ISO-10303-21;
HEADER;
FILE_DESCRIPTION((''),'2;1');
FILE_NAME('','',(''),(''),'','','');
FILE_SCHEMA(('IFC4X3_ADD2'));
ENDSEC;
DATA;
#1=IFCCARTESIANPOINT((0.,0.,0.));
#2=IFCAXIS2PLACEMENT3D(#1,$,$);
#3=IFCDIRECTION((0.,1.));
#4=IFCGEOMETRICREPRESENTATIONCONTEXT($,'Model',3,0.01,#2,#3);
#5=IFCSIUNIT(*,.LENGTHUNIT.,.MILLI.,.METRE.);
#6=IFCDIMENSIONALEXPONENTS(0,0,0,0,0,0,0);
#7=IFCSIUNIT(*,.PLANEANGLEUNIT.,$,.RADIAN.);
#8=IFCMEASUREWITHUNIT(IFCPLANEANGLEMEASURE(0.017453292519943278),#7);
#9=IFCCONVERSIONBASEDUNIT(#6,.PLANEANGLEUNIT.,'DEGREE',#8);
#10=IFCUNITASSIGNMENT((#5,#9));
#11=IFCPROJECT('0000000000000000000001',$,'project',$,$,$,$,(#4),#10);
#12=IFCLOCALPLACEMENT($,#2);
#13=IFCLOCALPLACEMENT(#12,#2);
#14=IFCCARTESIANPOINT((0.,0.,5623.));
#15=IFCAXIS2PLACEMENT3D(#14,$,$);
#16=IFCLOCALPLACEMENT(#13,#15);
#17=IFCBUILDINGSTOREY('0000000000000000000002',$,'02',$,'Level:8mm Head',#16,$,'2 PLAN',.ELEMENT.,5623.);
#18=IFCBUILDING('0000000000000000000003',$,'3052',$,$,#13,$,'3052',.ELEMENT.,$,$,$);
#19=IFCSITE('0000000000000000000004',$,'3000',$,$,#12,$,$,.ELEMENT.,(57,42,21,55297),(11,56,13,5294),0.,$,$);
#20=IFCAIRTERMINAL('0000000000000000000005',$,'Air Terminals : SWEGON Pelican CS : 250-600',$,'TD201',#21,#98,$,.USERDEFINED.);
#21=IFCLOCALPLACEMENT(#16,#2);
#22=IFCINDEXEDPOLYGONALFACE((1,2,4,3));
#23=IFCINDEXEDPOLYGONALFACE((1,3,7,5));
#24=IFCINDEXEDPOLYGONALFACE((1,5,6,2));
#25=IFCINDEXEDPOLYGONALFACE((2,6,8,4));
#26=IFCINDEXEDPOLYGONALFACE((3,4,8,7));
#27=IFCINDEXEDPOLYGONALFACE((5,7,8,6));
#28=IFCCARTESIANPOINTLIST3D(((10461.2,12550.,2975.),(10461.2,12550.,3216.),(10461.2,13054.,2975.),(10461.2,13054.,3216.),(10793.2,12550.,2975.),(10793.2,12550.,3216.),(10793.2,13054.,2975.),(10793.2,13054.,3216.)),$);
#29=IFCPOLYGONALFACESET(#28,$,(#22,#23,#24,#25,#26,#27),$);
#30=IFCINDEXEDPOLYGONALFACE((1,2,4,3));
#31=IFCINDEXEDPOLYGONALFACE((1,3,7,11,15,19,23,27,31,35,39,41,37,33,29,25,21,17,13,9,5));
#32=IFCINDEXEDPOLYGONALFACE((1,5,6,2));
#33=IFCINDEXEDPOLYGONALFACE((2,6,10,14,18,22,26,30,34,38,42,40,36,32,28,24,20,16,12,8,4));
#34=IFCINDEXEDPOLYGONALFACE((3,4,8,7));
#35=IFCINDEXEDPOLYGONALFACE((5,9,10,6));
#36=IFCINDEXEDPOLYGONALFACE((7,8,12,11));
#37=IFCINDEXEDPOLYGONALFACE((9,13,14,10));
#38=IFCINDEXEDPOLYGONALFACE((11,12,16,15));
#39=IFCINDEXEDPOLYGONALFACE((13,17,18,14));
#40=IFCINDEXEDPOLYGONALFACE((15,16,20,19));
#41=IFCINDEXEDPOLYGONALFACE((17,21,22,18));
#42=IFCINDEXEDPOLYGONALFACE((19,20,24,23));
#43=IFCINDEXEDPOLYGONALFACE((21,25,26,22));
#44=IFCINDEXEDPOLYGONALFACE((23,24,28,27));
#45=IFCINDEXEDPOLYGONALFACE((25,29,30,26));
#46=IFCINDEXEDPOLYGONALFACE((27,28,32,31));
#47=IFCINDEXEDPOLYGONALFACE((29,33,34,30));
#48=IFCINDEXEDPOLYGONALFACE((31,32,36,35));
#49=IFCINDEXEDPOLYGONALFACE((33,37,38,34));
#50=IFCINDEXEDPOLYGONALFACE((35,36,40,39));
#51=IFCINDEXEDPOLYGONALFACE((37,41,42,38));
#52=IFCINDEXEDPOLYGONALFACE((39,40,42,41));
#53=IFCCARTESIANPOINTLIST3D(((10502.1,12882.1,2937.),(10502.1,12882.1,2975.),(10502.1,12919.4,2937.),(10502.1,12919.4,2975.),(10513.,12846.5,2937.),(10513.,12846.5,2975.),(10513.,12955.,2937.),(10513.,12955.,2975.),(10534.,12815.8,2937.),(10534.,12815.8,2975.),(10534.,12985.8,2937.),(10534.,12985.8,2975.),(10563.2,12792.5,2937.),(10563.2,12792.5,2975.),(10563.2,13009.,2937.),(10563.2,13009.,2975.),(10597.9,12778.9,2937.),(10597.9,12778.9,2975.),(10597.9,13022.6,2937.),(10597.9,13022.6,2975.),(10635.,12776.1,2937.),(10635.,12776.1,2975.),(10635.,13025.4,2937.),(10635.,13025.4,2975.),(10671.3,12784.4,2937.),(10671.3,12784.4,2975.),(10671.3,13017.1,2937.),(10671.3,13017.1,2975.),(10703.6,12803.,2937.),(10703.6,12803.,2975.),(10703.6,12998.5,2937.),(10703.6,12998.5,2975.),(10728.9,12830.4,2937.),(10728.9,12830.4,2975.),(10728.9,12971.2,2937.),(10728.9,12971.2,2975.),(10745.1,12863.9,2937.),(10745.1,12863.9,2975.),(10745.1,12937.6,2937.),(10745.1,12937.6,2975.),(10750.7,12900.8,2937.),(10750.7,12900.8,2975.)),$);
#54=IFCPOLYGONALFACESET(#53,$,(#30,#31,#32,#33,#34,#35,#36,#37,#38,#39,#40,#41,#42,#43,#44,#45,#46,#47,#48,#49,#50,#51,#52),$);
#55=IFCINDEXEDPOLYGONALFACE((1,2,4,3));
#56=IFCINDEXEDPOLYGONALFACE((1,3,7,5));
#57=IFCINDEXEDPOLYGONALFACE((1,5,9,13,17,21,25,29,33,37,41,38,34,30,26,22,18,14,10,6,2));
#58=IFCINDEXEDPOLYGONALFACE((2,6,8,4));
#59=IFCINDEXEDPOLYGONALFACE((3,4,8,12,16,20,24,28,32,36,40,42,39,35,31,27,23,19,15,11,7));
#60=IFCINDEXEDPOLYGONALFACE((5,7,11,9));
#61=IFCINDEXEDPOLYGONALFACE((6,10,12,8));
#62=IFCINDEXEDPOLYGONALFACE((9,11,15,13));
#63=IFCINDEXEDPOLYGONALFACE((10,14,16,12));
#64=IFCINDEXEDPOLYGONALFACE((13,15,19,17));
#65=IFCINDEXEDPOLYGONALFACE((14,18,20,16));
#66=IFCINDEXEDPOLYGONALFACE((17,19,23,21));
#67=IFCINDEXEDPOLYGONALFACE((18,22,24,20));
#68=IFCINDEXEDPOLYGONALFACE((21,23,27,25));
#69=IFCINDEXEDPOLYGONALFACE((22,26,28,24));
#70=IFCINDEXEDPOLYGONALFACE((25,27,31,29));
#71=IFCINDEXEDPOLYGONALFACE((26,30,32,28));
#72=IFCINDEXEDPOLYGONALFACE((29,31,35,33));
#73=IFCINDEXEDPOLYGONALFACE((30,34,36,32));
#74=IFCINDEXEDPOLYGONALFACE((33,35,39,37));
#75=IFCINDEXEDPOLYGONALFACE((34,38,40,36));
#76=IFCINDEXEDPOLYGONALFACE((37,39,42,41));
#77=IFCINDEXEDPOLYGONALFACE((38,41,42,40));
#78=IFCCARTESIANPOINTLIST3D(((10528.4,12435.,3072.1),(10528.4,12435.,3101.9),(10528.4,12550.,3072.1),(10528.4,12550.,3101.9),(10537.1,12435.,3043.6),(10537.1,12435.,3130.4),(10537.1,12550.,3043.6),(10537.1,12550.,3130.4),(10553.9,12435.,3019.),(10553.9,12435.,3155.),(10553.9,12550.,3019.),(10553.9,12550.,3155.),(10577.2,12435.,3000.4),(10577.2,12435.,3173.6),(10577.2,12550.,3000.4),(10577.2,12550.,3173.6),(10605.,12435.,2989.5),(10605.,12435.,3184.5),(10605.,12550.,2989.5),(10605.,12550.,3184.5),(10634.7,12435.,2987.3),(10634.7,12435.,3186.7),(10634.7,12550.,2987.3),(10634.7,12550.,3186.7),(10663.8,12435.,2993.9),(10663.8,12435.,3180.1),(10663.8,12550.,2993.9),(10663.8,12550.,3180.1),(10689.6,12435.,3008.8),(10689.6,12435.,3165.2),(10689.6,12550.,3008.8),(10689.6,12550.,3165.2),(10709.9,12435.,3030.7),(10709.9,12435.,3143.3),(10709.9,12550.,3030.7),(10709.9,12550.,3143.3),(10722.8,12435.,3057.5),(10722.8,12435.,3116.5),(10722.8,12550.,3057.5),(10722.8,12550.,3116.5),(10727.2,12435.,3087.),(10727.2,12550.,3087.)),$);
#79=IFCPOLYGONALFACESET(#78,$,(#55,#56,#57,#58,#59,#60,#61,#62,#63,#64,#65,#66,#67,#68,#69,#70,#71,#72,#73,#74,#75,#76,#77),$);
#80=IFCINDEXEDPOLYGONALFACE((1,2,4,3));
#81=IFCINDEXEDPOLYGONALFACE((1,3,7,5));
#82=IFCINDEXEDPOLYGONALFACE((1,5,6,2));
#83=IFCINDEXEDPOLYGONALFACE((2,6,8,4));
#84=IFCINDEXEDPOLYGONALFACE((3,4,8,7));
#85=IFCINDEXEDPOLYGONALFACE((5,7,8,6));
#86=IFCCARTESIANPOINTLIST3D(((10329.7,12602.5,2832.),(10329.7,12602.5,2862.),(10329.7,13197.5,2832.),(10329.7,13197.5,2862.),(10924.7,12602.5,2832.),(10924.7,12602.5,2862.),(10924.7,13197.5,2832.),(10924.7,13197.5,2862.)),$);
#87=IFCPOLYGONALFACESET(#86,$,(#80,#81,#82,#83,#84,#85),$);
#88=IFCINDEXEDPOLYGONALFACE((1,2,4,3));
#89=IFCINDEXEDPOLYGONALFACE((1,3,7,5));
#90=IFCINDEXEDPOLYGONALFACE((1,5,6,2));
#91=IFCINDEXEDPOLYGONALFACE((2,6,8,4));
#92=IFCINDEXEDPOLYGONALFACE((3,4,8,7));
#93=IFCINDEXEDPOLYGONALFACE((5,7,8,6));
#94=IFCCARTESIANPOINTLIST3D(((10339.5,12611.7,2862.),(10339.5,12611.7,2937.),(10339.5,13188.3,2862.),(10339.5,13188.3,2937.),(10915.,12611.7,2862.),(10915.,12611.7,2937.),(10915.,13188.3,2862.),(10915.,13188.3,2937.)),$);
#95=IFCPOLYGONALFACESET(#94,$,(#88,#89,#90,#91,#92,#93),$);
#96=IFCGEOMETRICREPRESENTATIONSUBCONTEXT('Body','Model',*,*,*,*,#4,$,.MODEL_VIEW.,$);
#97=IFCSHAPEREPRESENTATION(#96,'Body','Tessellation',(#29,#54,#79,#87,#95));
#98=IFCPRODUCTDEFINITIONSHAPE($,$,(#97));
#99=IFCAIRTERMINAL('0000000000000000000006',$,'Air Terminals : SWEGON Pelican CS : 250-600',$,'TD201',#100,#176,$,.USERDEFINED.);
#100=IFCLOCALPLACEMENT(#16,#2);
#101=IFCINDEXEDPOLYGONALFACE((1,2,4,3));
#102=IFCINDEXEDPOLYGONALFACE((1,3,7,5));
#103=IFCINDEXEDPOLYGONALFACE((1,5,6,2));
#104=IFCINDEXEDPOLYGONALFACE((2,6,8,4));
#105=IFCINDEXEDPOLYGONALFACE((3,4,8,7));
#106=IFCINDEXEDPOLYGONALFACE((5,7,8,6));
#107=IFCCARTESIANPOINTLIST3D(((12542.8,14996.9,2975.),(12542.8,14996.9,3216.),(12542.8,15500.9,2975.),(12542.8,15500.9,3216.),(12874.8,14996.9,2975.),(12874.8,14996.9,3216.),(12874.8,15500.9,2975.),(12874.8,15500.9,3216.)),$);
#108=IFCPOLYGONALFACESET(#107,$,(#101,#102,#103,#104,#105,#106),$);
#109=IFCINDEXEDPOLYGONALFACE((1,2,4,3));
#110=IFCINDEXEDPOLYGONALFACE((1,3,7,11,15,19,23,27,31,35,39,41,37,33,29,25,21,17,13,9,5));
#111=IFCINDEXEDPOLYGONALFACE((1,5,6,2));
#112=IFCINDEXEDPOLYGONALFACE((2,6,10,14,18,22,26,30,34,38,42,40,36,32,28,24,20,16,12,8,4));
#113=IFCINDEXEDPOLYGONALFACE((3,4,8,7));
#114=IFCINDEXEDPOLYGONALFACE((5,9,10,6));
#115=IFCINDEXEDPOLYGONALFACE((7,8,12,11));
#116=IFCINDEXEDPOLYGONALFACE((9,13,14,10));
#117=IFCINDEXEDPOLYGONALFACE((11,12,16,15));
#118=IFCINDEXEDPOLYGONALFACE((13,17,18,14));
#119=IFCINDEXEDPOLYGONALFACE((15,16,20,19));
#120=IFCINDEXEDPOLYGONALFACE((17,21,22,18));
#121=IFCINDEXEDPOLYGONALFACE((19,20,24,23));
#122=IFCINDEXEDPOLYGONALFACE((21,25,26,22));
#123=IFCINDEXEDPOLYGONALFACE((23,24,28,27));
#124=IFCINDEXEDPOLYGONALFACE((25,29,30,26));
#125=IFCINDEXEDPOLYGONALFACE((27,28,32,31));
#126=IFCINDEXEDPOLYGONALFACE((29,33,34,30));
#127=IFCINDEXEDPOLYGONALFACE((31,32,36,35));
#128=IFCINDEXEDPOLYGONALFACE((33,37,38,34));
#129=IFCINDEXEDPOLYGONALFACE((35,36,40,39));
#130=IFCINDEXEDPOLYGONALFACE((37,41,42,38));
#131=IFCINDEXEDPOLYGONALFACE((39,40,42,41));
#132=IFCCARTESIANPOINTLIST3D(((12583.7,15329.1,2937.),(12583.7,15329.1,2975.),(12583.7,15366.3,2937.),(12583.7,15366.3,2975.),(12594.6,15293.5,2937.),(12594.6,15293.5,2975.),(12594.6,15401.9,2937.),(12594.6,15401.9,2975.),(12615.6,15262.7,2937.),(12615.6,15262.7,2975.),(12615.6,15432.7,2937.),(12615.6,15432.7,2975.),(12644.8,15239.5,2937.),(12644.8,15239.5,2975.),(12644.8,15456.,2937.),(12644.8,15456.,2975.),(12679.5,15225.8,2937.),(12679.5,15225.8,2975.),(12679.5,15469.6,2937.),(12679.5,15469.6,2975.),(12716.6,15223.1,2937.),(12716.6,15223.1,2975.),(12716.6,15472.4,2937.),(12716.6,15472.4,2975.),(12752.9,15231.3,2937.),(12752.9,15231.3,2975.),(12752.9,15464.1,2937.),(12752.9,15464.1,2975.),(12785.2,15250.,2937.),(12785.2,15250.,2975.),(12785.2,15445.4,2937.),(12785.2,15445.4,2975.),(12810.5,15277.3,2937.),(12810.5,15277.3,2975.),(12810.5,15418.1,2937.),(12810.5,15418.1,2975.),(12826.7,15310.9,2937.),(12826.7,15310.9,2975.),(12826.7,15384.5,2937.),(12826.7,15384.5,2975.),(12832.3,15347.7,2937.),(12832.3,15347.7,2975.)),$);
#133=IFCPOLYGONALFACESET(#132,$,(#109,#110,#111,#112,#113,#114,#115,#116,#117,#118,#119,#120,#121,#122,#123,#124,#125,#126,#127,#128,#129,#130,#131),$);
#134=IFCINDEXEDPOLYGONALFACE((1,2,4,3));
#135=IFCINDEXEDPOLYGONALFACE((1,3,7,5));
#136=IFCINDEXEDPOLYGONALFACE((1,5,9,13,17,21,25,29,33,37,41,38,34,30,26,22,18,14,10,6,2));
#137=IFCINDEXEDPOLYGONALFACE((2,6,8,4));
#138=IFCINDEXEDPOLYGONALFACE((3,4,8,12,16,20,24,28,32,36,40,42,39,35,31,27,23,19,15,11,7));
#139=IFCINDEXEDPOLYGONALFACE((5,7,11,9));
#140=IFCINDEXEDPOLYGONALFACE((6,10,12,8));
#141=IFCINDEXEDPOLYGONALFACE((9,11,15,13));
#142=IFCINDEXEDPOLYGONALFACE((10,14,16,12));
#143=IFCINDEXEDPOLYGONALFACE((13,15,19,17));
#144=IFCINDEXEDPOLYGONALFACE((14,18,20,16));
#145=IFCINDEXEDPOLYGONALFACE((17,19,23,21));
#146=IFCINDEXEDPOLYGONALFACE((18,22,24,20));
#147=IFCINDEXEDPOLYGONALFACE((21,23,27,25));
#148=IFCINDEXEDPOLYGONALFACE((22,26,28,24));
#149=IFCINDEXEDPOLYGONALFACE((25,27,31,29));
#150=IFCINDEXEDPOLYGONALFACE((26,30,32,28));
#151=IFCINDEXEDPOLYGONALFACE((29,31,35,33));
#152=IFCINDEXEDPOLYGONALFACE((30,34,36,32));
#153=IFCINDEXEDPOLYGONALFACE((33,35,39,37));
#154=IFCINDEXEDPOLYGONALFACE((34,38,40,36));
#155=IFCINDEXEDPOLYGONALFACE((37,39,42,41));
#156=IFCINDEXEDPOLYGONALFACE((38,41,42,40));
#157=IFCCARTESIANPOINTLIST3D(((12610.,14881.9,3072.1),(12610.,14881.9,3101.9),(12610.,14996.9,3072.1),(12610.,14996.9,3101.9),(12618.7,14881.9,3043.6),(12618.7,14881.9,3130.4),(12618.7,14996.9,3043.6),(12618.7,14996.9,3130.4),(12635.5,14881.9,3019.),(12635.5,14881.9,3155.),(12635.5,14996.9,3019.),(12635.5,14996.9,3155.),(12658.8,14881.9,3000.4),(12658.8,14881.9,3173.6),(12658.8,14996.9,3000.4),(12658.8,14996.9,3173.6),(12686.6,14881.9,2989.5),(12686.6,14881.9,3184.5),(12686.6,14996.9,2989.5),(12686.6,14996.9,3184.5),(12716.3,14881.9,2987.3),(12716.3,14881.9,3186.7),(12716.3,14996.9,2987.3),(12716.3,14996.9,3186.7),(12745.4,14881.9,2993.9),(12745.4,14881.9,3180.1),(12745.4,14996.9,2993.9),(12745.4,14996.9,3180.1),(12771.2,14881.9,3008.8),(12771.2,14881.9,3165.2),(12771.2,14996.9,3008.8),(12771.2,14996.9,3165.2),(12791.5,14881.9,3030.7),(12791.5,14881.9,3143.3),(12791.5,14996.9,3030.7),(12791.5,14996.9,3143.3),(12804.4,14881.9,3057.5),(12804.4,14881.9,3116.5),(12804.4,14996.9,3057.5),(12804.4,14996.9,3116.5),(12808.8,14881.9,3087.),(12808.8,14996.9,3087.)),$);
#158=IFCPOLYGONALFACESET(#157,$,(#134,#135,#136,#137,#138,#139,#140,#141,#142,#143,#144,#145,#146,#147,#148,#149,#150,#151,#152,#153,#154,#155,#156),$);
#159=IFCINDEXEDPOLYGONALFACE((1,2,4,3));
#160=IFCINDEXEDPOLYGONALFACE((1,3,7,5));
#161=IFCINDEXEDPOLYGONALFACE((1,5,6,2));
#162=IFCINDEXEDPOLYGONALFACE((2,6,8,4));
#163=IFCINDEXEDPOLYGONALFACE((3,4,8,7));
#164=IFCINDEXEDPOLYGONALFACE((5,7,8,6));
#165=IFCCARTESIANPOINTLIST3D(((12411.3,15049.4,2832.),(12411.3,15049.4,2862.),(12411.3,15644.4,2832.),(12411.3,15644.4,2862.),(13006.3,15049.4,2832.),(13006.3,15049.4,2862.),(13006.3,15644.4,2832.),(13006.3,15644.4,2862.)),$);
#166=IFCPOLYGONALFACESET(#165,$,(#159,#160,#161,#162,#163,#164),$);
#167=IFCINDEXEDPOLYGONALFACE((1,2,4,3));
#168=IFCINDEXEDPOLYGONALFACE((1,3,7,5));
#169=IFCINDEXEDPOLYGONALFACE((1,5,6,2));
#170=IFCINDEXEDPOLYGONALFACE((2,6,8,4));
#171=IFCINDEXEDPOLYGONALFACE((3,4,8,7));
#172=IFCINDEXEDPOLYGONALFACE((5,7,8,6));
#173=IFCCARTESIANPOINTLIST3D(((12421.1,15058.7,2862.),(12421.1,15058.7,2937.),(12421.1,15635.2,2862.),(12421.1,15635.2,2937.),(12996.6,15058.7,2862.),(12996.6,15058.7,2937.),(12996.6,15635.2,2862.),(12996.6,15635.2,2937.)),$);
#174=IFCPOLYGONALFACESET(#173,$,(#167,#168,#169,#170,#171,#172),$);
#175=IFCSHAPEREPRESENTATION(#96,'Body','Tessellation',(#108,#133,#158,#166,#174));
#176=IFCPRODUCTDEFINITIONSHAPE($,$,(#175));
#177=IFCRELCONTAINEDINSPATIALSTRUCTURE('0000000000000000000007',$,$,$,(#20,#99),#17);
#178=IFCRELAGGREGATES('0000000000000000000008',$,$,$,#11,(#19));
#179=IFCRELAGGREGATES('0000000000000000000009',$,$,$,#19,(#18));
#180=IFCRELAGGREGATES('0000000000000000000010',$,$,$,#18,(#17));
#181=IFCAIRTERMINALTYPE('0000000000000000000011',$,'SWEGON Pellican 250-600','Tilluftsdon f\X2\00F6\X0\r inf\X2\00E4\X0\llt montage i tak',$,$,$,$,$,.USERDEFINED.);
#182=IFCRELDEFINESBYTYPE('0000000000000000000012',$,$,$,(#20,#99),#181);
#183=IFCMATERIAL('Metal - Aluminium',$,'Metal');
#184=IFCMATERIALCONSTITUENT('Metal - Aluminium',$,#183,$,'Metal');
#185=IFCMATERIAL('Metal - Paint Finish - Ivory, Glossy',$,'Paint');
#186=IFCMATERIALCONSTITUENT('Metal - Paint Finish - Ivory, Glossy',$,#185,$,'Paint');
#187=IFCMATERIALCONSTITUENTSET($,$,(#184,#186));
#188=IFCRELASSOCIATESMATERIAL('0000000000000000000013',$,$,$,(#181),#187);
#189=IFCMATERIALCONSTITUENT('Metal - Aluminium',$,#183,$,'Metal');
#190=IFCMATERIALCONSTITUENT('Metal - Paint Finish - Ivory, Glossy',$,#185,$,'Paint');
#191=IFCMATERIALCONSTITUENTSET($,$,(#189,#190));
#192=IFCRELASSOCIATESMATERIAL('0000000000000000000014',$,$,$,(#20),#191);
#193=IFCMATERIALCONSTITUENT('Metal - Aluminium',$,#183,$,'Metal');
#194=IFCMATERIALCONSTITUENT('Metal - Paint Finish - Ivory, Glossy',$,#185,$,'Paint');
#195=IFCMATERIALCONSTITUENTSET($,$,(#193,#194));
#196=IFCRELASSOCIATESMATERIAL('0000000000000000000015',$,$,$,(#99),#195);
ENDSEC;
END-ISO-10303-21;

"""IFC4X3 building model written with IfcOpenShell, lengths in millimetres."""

from ifc_helpers import new_model, entity, si_unit, converted_unit, direction, frame, frame_2d, origin, origin_2d_with_axis, place, context, subcontext, project, spatial, rectangle, circle, extrude, source, transform, mapped, material, constituent, constituent_set, type_object, type_shapes, element, save


model = new_model("IFC4X3")

# Units and contexts
model_context = context("Model", 3, precision=0.01, world=origin(), true_north=direction((0.0, 1.0)))
body_context = subcontext(model_context, "Body", "Model", "MODEL_VIEW")
ifc_project = project(units=[si_unit("LENGTHUNIT", "METRE", prefix="MILLI"), converted_unit("PLANEANGLEUNIT", "DEGREE", entity("IfcPlaneAngleMeasure", 0.017453292519943278), si_unit("PLANEANGLEUNIT", "RADIAN"), dimensions=[0, 0, 0, 0, 0, 0, 0])], contexts=[model_context])

# Site, building, storey
site_placement = place(None, origin())
site = spatial("IfcSite", under=ifc_project, at=site_placement, Name="3000", CompositionType="ELEMENT", RefLatitude=(57, 42, 21, 55297), RefLongitude=(11, 56, 13, 5294), RefElevation=0.0)
building_placement = place(site_placement, origin())
building = spatial("IfcBuilding", under=site, at=building_placement, Name="3052", LongName="3052", CompositionType="ELEMENT")
storey_placement = place(building_placement, frame((0.0, 0.0, 5623.0)))
storey = spatial("IfcBuildingStorey", under=building, at=storey_placement, Name="02", ObjectType="Level:8mm Head", LongName="2 PLAN", CompositionType="ELEMENT", Elevation=5623.0)

# Air terminals
ifc_material_1 = material(Name="Metal - Aluminium", Category="Metal")
ifc_constituent_1 = constituent(ifc_material_1, Name="Metal - Aluminium", Category="Metal")
ifc_material_2 = material(Name="Metal - Paint Finish - Ivory, Glossy", Category="Paint")
ifc_constituent_2 = constituent(ifc_material_2, Name="Metal - Paint Finish - Ivory, Glossy", Category="Paint")
ifc_constituent_set_1 = constituent_set(constituents=[ifc_constituent_1, ifc_constituent_2])
ifc_constituent_3 = constituent(ifc_material_1, Name="Metal - Aluminium", Category="Metal")
ifc_constituent_4 = constituent(ifc_material_2, Name="Metal - Paint Finish - Ivory, Glossy", Category="Paint")
ifc_constituent_set_2 = constituent_set(constituents=[ifc_constituent_3, ifc_constituent_4])
air_terminal_type_1 = type_object("IfcAirTerminalType", Name="SWEGON Pellican 250-600", Description="Tilluftsdon för infällt montage i tak", PredefinedType="USERDEFINED", material=ifc_constituent_set_2)
shared_shape_1 = source(origin(), body_context, "Body", "SweptSolid", [
    extrude(rectangle(XDim=332.0, YDim=504.0, at=origin_2d_with_axis()), frame((0.0, 98.0, -354.0), z_axis=(0.0, 0.0, 1.0), x_axis=(-1.0, 0.0, 0.0)), (0.0, 0.0, 1.0), 241.0),
    extrude(circle(Radius=125.0, at=frame_2d((0.0, 0.0), x_axis=(1.0, 0.0))), frame((-1.6, -0.8, -113.0)), (0.0, 0.0, 1.0), 38.0),
    extrude(circle(Radius=100.0, at=frame_2d((0.0, 0.0), x_axis=(1.0, 0.0))), frame((0.0, 350.0, -225.0), z_axis=(0.0, 1.0, 0.0), x_axis=(1.0, 0.0, 0.0)), (0.0, 0.0, 1.0), 115.0),
    extrude(rectangle(XDim=595.0, YDim=595.0, at=frame_2d((0.0, 0.0), x_axis=(1.0, 0.0))), frame((0.0, 0.0, 0.0), z_axis=(0.0, 0.0, 1.0), x_axis=(-1.0, 0.0, 0.0)), (0.0, 0.0, 1.0), 30.0),
    extrude(rectangle(XDim=575.5, YDim=576.5, at=origin_2d_with_axis()), frame((0.0, 0.0, -75.0), z_axis=(0.0, 0.0, 1.0), x_axis=(-1.0, 0.0, 0.0)), (0.0, 0.0, 1.0), 75.0),
])
type_shapes(air_terminal_type_1, [shared_shape_1])
air_terminal_1_placement = place(storey_placement, frame((10627.2, 12900.0, 2862.0), z_axis=(0.0, 0.0, -1.0), x_axis=(1.0, 0.0, 0.0)))
element("IfcAirTerminal", 1, at=air_terminal_1_placement, inside=storey, type_object=air_terminal_type_1, material=ifc_constituent_set_1, Name="Air Terminals : SWEGON Pelican CS : 250-600", ObjectType="TD201", PredefinedType="USERDEFINED", context=body_context, shape_type="MappedRepresentation", body=[
    mapped(shared_shape_1, transform((0.0, 0.0, 0.0), scale=1.0)),
])
ifc_constituent_5 = constituent(ifc_material_1, Name="Metal - Aluminium", Category="Metal")
ifc_constituent_6 = constituent(ifc_material_2, Name="Metal - Paint Finish - Ivory, Glossy", Category="Paint")
ifc_constituent_set_3 = constituent_set(constituents=[ifc_constituent_5, ifc_constituent_6])
air_terminal_2_placement = place(storey_placement, frame((12708.8, 15346.9, 2862.0), z_axis=(0.0, 0.0, -1.0), x_axis=(1.0, 0.0, 0.0)))
element("IfcAirTerminal", 2, at=air_terminal_2_placement, inside=storey, type_object=air_terminal_type_1, material=ifc_constituent_set_3, Name="Air Terminals : SWEGON Pelican CS : 250-600", ObjectType="TD201", PredefinedType="USERDEFINED", context=body_context, shape_type="MappedRepresentation", body=[
    mapped(shared_shape_1, transform((0.0, 0.0, 0.0), scale=1.0)),
])

save(model, "model.ifc")
